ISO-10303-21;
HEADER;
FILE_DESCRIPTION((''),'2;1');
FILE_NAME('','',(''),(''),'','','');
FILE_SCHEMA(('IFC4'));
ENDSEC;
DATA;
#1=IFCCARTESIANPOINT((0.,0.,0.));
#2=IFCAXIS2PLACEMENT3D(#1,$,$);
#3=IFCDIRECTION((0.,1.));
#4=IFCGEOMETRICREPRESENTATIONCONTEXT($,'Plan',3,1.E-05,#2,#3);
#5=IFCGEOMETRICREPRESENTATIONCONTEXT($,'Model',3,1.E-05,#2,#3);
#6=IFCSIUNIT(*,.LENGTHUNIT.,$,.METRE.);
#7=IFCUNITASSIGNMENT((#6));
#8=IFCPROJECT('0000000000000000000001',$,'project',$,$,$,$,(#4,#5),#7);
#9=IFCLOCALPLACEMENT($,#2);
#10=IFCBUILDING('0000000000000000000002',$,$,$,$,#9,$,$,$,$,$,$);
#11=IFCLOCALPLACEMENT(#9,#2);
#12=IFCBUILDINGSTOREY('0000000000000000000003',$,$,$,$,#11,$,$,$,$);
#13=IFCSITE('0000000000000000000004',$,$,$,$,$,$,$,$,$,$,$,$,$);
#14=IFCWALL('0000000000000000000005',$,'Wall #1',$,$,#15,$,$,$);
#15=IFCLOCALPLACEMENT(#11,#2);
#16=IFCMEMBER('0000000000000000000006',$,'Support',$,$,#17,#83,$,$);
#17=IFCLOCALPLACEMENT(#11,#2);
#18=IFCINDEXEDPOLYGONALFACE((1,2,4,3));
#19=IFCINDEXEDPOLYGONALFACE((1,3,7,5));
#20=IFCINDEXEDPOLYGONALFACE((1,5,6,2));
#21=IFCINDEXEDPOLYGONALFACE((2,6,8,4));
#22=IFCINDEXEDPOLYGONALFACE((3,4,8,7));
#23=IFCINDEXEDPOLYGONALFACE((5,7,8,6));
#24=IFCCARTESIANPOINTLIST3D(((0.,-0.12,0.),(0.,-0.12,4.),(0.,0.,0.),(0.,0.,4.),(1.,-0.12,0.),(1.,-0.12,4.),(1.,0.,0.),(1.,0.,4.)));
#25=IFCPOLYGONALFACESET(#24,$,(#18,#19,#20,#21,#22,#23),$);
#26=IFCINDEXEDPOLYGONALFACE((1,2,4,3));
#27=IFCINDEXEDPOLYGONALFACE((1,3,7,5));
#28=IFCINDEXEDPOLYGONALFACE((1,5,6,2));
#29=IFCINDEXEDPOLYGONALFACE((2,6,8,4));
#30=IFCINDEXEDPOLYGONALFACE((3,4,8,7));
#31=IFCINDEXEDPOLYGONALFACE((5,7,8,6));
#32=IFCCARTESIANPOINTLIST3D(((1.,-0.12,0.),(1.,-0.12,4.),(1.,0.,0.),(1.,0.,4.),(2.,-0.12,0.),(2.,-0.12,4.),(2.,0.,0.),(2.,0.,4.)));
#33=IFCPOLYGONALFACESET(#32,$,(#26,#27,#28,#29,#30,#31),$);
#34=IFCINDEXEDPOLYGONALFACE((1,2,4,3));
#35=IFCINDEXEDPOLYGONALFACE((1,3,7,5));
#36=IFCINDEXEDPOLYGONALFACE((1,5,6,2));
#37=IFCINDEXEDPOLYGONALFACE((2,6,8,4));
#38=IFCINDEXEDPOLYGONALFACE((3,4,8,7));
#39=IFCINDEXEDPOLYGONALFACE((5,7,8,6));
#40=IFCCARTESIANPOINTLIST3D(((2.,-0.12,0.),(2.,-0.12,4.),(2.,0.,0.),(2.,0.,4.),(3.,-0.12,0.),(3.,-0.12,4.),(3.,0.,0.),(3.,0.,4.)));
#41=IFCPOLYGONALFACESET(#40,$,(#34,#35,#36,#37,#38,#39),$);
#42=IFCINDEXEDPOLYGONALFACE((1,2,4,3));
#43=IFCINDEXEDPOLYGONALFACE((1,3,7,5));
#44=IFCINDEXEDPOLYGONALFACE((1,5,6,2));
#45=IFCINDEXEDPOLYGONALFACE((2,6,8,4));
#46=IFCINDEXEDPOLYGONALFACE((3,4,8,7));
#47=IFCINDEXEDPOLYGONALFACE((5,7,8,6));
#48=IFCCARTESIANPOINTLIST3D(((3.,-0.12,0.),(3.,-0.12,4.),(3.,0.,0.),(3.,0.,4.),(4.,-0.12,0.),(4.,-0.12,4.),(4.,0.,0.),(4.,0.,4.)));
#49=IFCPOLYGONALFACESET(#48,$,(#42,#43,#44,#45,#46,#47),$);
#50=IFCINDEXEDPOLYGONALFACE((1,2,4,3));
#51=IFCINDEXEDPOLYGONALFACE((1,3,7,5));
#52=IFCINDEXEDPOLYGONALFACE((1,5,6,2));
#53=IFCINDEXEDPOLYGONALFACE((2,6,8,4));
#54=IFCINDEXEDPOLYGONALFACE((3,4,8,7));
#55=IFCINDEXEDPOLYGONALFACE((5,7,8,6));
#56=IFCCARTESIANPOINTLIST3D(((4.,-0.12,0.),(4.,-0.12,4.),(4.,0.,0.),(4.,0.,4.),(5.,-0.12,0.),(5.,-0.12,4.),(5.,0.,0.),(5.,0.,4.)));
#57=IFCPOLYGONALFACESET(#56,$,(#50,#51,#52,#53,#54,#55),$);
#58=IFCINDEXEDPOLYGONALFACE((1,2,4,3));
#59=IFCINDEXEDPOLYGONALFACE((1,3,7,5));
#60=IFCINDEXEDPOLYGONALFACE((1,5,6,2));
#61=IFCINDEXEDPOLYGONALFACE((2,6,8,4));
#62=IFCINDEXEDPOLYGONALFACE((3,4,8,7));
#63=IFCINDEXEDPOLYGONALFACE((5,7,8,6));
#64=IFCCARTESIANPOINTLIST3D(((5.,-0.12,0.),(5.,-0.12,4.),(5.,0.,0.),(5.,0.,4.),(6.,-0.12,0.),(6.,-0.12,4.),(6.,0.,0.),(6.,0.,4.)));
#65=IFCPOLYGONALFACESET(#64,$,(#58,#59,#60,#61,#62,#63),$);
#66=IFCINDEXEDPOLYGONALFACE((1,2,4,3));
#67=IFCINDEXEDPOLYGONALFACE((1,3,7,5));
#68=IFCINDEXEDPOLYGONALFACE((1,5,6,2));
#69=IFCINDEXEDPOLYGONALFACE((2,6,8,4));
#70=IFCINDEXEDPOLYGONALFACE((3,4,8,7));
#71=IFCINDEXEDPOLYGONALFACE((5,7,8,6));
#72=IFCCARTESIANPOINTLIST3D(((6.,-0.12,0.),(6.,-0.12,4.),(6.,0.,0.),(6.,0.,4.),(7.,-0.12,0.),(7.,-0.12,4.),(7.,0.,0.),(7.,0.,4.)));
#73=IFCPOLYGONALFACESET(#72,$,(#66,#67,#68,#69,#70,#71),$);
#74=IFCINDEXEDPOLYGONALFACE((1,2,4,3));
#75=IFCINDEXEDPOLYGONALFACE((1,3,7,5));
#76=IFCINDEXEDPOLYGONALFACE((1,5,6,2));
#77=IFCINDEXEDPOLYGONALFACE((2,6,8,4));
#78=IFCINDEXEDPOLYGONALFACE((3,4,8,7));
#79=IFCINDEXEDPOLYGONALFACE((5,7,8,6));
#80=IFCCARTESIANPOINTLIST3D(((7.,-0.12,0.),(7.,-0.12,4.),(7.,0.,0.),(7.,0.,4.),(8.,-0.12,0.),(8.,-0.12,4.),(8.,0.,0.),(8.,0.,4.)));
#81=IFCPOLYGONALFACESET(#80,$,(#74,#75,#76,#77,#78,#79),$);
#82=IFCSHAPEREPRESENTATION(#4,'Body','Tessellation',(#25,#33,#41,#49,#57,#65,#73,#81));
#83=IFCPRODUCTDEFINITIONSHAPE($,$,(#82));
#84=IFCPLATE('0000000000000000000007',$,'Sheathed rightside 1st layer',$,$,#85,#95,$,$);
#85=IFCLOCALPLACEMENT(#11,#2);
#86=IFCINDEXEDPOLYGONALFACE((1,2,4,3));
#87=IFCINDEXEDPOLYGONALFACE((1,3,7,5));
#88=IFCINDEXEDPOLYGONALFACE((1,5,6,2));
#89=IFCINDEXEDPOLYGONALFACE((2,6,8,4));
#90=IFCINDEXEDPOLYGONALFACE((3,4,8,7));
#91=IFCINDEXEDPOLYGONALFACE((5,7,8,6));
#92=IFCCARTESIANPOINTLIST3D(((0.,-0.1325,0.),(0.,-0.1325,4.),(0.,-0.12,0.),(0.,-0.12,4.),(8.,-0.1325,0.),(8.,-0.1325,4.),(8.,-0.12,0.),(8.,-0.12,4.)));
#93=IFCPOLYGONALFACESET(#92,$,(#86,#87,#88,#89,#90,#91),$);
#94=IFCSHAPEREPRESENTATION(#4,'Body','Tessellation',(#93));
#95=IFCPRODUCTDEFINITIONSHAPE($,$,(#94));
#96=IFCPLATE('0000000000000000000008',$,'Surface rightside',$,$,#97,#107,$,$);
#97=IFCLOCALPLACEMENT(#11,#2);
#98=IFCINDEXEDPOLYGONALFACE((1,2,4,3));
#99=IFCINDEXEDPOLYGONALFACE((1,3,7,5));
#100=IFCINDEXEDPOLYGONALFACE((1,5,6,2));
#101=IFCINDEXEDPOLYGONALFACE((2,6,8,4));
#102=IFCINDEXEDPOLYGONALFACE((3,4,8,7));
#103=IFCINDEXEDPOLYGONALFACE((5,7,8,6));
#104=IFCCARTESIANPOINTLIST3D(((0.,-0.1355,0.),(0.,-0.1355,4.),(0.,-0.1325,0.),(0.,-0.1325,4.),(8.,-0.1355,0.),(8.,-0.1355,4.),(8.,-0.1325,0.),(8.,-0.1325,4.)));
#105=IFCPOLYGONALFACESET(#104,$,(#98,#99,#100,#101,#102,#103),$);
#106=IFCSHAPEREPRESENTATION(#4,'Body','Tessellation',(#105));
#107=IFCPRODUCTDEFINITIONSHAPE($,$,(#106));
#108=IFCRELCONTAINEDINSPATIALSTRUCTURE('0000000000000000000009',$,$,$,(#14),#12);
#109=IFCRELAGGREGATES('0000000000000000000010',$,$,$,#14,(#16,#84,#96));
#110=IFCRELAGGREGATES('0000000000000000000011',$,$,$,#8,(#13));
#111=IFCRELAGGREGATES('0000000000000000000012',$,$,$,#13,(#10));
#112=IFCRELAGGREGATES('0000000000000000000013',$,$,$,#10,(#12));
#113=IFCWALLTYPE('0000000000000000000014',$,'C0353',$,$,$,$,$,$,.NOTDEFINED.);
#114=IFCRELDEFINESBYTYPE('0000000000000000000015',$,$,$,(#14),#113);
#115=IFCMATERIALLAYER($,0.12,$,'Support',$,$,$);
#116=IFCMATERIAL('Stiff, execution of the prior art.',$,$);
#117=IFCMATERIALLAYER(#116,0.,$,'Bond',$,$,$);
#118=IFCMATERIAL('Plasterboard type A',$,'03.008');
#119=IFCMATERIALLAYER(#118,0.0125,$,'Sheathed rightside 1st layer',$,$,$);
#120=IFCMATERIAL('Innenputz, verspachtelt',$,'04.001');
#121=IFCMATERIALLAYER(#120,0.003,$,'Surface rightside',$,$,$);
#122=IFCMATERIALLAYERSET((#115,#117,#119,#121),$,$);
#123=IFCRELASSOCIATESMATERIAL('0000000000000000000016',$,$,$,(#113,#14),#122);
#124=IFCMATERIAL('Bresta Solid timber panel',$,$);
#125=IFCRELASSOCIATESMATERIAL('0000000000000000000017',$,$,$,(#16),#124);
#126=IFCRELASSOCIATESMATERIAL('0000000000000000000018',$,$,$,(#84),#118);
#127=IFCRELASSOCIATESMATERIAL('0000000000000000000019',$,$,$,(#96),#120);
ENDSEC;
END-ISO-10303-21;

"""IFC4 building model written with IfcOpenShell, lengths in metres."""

from ifc_helpers import new_model, si_unit, direction, frame, frame_2d, origin, place, context, project, spatial, rectangle, extrude, material, layer, layer_set, type_object, element, aggregate, save


model = new_model("IFC4")

# Units and contexts
plan_context = context("Plan", 3, precision=1e-05, world=origin(), true_north=direction((0.0, 1.0)))
model_context = context("Model", 3, precision=1e-05, world=origin(), true_north=direction((0.0, 1.0)))
ifc_project = project(units=[si_unit("LENGTHUNIT", "METRE")], contexts=[plan_context, model_context])

# Site, building, storey
site = spatial("IfcSite", under=ifc_project)
building_placement = place(None, origin())
building = spatial("IfcBuilding", under=site, at=building_placement)
storey_placement = place(building_placement, origin())
storey = spatial("IfcBuildingStorey", under=building, at=storey_placement)

# Wall, member, plates
ifc_layer_1 = layer(None, 0.12, Name="Support")
ifc_material_1 = material(Name="Stiff, execution of the prior art.")
ifc_layer_2 = layer(ifc_material_1, 0.0, Name="Bond")
ifc_material_2 = material(Name="Plasterboard type A", Category="03.008")
ifc_layer_3 = layer(ifc_material_2, 0.0125, Name="Sheathed rightside 1st layer")
ifc_material_3 = material(Name="Innenputz, verspachtelt", Category="04.001")
ifc_layer_4 = layer(ifc_material_3, 0.003, Name="Surface rightside")
ifc_layer_set = layer_set([ifc_layer_1, ifc_layer_2, ifc_layer_3, ifc_layer_4])
wall_type = type_object("IfcWallType", Name="C0353", PredefinedType="NOTDEFINED", material=ifc_layer_set)
wall_placement = place(None, frame((0.0, 0.0, 0.0), z_axis=(0.0, -1.0, 0.0), x_axis=(1.0, 0.0, 0.0)))
wall = element("IfcWall", 1, at=wall_placement, inside=storey, type_object=wall_type, material=ifc_layer_set, Name="Wall #1")
ifc_material_4 = material(Name="Bresta Solid timber panel")
member_placement = place(wall_placement, origin())
member = element("IfcMember", 2, at=member_placement, material=ifc_material_4, Name="Support", context=plan_context, shape_type="SweptSolid", body=[
    extrude(rectangle(XDim=1.0, YDim=0.12, at=frame_2d((0.5, 0.06), x_axis=(1.0, 0.0))), frame((0.0, 4.0, 0.0), z_axis=(0.0, -1.0, 0.0), x_axis=(1.0, 0.0, 0.0)), (0.0, 0.0, 1.0), 4.0),
    extrude(rectangle(XDim=1.0, YDim=0.12, at=frame_2d((0.5, 0.06), x_axis=(1.0, 0.0))), frame((1.0, 4.0, 0.0), z_axis=(0.0, -1.0, 0.0), x_axis=(1.0, 0.0, 0.0)), (0.0, 0.0, 1.0), 4.0),
    extrude(rectangle(XDim=1.0, YDim=0.12, at=frame_2d((0.5, 0.06), x_axis=(1.0, 0.0))), frame((2.0, 4.0, 0.0), z_axis=(0.0, -1.0, 0.0), x_axis=(1.0, 0.0, 0.0)), (0.0, 0.0, 1.0), 4.0),
    extrude(rectangle(XDim=1.0, YDim=0.12, at=frame_2d((0.5, 0.06), x_axis=(1.0, 0.0))), frame((3.0, 4.0, 0.0), z_axis=(0.0, -1.0, 0.0), x_axis=(1.0, 0.0, 0.0)), (0.0, 0.0, 1.0), 4.0),
    extrude(rectangle(XDim=1.0, YDim=0.12, at=frame_2d((0.5, 0.06), x_axis=(1.0, 0.0))), frame((4.0, 4.0, 0.0), z_axis=(0.0, -1.0, 0.0), x_axis=(1.0, 0.0, 0.0)), (0.0, 0.0, 1.0), 4.0),
    extrude(rectangle(XDim=1.0, YDim=0.12, at=frame_2d((0.5, 0.06), x_axis=(1.0, 0.0))), frame((5.0, 4.0, 0.0), z_axis=(0.0, -1.0, 0.0), x_axis=(1.0, 0.0, 0.0)), (0.0, 0.0, 1.0), 4.0),
    extrude(rectangle(XDim=1.0, YDim=0.12, at=frame_2d((0.5, 0.06), x_axis=(1.0, 0.0))), frame((6.0, 4.0, 0.0), z_axis=(0.0, -1.0, 0.0), x_axis=(1.0, 0.0, 0.0)), (0.0, 0.0, 1.0), 4.0),
    extrude(rectangle(XDim=1.0, YDim=0.12, at=frame_2d((0.5, 0.06), x_axis=(1.0, 0.0))), frame((7.0, 4.0, 0.0), z_axis=(0.0, -1.0, 0.0), x_axis=(1.0, 0.0, 0.0)), (0.0, 0.0, 1.0), 4.0),
])
plate_1_placement = place(wall_placement, origin())
plate_1 = element("IfcPlate", 3, at=plate_1_placement, material=ifc_material_2, Name="Sheathed rightside 1st layer", context=plan_context, shape_type="SweptSolid", body=[
    extrude(rectangle(XDim=8.0, YDim=4.0, at=frame_2d((4.0, 2.0), x_axis=(1.0, 0.0))), frame((0.0, 0.0, 0.12), z_axis=(0.0, 0.0, 1.0), x_axis=(1.0, 0.0, 0.0)), (0.0, 0.0, 1.0), 0.0125),
])
plate_2_placement = place(wall_placement, origin())
plate_2 = element("IfcPlate", 4, at=plate_2_placement, material=ifc_material_3, Name="Surface rightside", context=plan_context, shape_type="SweptSolid", body=[
    extrude(rectangle(XDim=8.0, YDim=4.0, at=frame_2d((4.0, 2.0), x_axis=(1.0, 0.0))), frame((0.0, 0.0, 0.1325), z_axis=(0.0, 0.0, 1.0), x_axis=(1.0, 0.0, 0.0)), (0.0, 0.0, 1.0), 0.003),
])
aggregate(wall, [member, plate_1, plate_2])

save(model, "model.ifc")
